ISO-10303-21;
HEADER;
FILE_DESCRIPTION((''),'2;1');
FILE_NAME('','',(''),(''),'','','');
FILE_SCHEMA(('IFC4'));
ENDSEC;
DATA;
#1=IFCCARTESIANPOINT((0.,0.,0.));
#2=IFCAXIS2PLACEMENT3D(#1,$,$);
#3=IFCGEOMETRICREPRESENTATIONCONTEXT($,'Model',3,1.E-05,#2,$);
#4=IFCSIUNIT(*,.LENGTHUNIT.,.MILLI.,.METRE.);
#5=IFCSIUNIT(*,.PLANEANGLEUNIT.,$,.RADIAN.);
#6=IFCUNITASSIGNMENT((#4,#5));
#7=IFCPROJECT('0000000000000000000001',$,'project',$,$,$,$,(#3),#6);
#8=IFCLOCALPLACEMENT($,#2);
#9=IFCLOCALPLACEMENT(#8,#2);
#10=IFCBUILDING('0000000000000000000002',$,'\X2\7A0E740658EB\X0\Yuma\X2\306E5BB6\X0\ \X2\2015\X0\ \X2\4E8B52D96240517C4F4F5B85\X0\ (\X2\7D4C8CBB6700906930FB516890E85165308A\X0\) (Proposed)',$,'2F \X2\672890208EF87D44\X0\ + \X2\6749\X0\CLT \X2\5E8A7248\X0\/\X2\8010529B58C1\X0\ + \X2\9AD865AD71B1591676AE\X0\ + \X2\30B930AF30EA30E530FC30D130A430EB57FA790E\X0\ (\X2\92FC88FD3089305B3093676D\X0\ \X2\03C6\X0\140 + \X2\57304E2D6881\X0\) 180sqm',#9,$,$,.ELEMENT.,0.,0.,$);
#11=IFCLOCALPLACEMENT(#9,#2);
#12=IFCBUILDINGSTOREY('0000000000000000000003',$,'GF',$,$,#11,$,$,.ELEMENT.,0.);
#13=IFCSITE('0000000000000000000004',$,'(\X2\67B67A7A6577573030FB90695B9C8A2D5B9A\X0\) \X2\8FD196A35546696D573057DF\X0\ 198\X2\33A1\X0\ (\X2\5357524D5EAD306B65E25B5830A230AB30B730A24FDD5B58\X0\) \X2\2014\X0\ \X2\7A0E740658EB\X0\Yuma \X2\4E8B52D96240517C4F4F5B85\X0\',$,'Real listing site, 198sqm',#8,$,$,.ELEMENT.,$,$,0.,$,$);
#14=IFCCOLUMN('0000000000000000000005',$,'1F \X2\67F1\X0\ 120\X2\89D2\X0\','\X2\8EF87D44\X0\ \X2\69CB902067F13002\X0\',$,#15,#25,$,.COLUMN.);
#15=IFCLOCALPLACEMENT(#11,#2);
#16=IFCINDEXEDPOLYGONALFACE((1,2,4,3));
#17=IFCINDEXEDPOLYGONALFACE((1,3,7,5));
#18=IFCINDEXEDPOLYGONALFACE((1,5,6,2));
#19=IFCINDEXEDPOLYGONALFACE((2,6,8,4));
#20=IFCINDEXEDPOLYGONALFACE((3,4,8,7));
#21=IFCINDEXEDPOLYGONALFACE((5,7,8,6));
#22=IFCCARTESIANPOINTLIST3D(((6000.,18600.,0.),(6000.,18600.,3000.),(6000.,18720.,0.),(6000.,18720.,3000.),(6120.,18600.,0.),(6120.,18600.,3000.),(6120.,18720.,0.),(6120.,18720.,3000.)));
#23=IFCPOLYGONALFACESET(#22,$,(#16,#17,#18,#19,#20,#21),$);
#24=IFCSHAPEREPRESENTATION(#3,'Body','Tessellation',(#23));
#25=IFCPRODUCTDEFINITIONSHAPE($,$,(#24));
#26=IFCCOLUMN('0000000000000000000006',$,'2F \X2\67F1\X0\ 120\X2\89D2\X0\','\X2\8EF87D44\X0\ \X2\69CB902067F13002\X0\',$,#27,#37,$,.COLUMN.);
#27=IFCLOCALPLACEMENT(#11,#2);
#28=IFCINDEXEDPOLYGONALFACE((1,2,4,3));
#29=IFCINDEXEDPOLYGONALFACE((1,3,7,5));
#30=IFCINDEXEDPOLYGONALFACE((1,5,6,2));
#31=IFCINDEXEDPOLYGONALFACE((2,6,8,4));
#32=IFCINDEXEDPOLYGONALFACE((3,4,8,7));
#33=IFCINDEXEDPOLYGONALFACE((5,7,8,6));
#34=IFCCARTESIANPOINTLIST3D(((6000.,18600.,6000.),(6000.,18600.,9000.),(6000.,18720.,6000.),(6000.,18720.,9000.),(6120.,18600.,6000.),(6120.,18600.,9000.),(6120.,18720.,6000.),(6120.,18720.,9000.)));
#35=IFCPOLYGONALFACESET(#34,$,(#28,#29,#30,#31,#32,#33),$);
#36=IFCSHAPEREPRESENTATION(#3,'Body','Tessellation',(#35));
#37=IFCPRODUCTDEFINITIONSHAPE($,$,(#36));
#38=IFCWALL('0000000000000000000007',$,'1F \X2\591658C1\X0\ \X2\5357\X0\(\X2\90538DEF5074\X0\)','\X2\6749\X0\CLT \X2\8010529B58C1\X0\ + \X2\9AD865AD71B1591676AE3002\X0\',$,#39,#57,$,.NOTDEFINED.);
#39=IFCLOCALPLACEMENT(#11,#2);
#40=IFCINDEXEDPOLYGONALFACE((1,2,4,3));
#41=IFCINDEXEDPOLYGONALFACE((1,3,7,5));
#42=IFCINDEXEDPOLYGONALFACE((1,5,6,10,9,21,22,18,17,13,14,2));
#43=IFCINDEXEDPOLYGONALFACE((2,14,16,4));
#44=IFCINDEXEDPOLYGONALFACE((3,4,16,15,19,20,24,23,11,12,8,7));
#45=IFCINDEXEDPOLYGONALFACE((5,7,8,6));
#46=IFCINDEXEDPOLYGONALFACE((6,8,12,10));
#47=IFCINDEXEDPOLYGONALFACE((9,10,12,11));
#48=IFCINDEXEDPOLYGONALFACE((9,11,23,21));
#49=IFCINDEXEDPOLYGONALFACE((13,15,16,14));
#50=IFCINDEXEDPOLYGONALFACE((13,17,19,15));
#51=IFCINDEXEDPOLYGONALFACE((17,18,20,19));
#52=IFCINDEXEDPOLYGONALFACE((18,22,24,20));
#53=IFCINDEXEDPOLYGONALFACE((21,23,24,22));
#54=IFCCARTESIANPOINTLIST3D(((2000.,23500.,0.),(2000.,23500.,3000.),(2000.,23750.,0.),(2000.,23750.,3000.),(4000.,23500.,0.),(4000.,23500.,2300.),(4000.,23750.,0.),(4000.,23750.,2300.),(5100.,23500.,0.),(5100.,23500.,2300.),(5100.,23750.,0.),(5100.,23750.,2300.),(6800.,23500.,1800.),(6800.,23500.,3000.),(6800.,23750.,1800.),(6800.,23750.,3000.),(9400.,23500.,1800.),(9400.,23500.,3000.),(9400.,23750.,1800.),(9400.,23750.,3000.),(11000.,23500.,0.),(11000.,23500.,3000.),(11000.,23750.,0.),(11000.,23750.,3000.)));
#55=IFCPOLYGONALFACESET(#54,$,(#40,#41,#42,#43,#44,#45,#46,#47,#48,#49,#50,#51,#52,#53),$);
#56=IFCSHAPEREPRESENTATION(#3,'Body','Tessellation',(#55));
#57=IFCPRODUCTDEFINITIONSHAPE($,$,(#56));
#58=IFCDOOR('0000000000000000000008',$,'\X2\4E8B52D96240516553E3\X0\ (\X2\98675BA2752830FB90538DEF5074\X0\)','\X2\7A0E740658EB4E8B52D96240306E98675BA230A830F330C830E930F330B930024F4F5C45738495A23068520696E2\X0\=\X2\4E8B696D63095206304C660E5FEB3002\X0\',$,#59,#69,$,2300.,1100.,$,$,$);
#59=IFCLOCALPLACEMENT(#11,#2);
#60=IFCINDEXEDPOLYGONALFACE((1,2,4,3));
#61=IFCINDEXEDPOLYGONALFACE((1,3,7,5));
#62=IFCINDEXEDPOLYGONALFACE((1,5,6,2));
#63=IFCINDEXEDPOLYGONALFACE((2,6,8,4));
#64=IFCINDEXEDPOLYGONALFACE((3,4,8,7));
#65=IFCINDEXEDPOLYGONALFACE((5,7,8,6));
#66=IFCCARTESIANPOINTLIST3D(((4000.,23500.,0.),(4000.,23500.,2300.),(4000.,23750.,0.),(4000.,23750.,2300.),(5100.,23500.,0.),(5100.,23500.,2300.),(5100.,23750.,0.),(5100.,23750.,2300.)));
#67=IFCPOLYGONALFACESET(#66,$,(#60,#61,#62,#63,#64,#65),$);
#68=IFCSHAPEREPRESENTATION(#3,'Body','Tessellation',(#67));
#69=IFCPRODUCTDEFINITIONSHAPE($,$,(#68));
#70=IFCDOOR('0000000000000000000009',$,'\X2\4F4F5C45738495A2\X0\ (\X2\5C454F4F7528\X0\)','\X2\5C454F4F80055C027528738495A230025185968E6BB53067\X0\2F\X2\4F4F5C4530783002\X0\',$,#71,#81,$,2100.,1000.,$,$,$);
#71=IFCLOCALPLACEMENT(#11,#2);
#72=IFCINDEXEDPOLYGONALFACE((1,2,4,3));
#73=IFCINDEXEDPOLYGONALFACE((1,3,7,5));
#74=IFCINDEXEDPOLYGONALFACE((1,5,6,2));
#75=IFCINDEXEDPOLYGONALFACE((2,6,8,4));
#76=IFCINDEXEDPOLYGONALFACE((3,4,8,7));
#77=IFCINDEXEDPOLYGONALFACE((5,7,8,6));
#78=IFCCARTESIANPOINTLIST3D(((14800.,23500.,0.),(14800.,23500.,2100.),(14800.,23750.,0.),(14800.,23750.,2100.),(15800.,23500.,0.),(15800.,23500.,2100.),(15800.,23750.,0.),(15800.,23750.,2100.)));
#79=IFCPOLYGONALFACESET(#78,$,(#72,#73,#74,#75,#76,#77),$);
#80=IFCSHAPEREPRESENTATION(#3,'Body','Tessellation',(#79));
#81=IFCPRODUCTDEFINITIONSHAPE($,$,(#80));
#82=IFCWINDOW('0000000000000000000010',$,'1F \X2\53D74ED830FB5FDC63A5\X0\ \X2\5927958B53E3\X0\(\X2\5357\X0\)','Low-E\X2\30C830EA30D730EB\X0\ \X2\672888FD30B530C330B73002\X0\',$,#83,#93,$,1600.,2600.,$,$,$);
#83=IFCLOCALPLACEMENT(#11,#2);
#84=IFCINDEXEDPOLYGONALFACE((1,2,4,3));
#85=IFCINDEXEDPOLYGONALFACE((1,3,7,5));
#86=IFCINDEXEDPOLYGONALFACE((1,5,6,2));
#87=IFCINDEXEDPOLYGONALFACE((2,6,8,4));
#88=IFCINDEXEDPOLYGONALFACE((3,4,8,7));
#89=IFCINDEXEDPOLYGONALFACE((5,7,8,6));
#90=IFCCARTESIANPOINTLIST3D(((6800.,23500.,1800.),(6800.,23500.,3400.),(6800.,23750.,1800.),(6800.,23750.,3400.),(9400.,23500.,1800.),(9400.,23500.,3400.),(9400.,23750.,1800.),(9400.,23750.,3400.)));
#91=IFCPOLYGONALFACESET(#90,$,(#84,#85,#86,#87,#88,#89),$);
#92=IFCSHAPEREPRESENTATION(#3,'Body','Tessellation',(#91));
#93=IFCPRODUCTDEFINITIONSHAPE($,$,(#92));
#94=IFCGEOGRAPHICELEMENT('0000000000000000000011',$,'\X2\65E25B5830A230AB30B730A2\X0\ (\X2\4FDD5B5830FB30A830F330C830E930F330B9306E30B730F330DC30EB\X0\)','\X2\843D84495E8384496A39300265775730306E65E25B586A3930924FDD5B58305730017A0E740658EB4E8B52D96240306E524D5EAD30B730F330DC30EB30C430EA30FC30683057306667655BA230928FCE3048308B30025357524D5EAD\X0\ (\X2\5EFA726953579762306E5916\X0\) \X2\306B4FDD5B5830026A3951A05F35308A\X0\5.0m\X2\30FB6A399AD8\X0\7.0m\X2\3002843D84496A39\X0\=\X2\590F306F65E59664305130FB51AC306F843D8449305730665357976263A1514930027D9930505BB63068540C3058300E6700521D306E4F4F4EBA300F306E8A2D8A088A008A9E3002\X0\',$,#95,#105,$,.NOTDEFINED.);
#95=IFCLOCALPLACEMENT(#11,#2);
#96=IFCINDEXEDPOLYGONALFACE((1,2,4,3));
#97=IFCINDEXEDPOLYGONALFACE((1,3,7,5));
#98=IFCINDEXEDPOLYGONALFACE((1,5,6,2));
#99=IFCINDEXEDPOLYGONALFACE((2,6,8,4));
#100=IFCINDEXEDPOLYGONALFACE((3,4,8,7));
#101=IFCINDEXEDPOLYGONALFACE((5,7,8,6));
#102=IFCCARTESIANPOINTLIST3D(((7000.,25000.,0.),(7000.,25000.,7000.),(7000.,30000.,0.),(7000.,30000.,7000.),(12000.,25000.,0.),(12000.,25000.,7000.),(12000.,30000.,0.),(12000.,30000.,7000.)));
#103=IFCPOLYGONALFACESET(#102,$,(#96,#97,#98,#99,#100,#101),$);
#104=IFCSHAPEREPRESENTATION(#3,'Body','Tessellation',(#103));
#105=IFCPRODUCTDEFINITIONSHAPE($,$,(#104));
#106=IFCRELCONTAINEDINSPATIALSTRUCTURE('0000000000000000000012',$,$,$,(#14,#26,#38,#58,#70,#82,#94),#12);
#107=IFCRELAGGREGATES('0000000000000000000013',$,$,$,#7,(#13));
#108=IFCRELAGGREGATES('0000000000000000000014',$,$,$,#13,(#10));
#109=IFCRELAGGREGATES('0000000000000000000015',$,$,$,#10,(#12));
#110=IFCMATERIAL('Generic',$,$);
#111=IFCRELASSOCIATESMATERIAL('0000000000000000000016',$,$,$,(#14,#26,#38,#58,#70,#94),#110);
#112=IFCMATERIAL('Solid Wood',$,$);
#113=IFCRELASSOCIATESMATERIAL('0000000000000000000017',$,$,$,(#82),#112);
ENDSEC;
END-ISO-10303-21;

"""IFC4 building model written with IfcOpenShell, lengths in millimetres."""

from ifc_helpers import new_model, si_unit, frame, frame_2d, origin, place, context, project, spatial, rectangle, extrude, material, element, fill, save


model = new_model("IFC4")

# Units and contexts
model_context = context("Model", 3, precision=1e-05, world=origin())
ifc_project = project(units=[si_unit("LENGTHUNIT", "METRE", prefix="MILLI"), si_unit("PLANEANGLEUNIT", "RADIAN")], contexts=[model_context])

# Site, building, storey
site_placement = place(None, origin())
site = spatial("IfcSite", under=ifc_project, at=site_placement, Name="(架空敷地・適宜設定) 近隣商業地域 198㎡ (南前庭に既存アカシア保存) — 税理士Yuma 事務所兼住宅", ObjectType="Real listing site, 198sqm", CompositionType="ELEMENT", RefElevation=0.0)
building_placement = place(site_placement, origin())
building = spatial("IfcBuilding", under=site, at=building_placement, Name="税理士Yumaの家 ― 事務所兼住宅 (経費最適・全部入り) (Proposed)", ObjectType="2F 木造軸組 + 杉CLT 床版/耐力壁 + 高断熱外皮 + スクリューパイル基礎 (鋼製らせん杭 φ140 + 地中梁) 180sqm", CompositionType="ELEMENT", ElevationOfRefHeight=0.0, ElevationOfTerrain=0.0)
storey_placement = place(building_placement, origin())
storey = spatial("IfcBuildingStorey", under=building, at=storey_placement, Name="GF", CompositionType="ELEMENT", Elevation=0.0)

# Columns
ifc_material_1 = material(Name="Generic")
column_1_placement = place(storey_placement, frame((3000.0, 9300.0, 0.0)))
element("IfcColumn", 1, at=column_1_placement, inside=storey, material=ifc_material_1, Name="1F 柱 120角", Description="軸組 構造柱。", PredefinedType="COLUMN", context=model_context, shape_type="SweptSolid", body=[
    extrude(rectangle(XDim=120.0, YDim=120.0, at=frame_2d((60.0, 60.0))), frame((3000.0, 9300.0, 0.0)), (0.0, 0.0, 1.0), 3000.0),
])
column_2_placement = place(storey_placement, frame((3000.0, 9300.0, 3000.0)))
element("IfcColumn", 2, at=column_2_placement, inside=storey, material=ifc_material_1, Name="2F 柱 120角", Description="軸組 構造柱。", PredefinedType="COLUMN", context=model_context, shape_type="SweptSolid", body=[
    extrude(rectangle(XDim=120.0, YDim=120.0, at=frame_2d((60.0, 60.0))), frame((3000.0, 9300.0, 3000.0)), (0.0, 0.0, 1.0), 3000.0),
])

# Wall, openings, doors, window
wall_1_placement = place(storey_placement, frame((1000.0, 11750.0, 0.0)))
wall_1 = element("IfcWall", 3, at=wall_1_placement, inside=storey, material=ifc_material_1, Name="1F 外壁 南(道路側)", Description="杉CLT 耐力壁 + 高断熱外皮。", PredefinedType="NOTDEFINED", context=model_context, shape_type="SweptSolid", body=[
    extrude(rectangle(XDim=9000.0, YDim=250.0, at=frame_2d((4500.0, 125.0))), frame((1000.0, 11750.0, 0.0)), (0.0, 0.0, 1.0), 3000.0),
])
opening_1_placement = place(storey_placement, frame((2000.0, 11750.0, 0.0)))
opening_1 = element("IfcOpeningElement", 4, at=opening_1_placement, cuts=wall_1, PredefinedType="NOTDEFINED", context=model_context, shape_type="SweptSolid", body=[
    extrude(rectangle(XDim=1100.0, YDim=250.0, at=frame_2d((550.0, 125.0))), frame((2000.0, 11750.0, 0.0)), (0.0, 0.0, 1.0), 2300.0),
])
opening_2_placement = place(storey_placement, frame((7400.0, 11750.0, 0.0)))
opening_2 = element("IfcOpeningElement", 5, at=opening_2_placement, cuts=wall_1, PredefinedType="NOTDEFINED", context=model_context, shape_type="SweptSolid", body=[
    extrude(rectangle(XDim=1000.0, YDim=250.0, at=frame_2d((500.0, 125.0))), frame((7400.0, 11750.0, 0.0)), (0.0, 0.0, 1.0), 2100.0),
])
opening_3_placement = place(storey_placement, frame((3400.0, 11750.0, 900.0)))
opening_3 = element("IfcOpeningElement", 6, at=opening_3_placement, cuts=wall_1, PredefinedType="NOTDEFINED", context=model_context, shape_type="SweptSolid", body=[
    extrude(rectangle(XDim=2600.0, YDim=250.0, at=frame_2d((1300.0, 125.0))), frame((3400.0, 11750.0, 900.0)), (0.0, 0.0, 1.0), 1600.0),
])
door_1_placement = place(storey_placement, frame((2000.0, 11750.0, 0.0)))
door_1 = element("IfcDoor", 7, at=door_1_placement, inside=storey, material=ifc_material_1, Name="事務所入口 (顧客用・道路側)", Description="税理士事務所の顧客エントランス。住居玄関と分離=事業按分が明快。", OverallHeight=2300.0, OverallWidth=1100.0, context=model_context, shape_type="SweptSolid", body=[
    extrude(rectangle(XDim=1100.0, YDim=250.0, at=frame_2d((550.0, 125.0))), frame((2000.0, 11750.0, 0.0)), (0.0, 0.0, 1.0), 2300.0),
])
fill(opening_1, door_1)
door_2_placement = place(storey_placement, frame((7400.0, 11750.0, 0.0)))
door_2 = element("IfcDoor", 8, at=door_2_placement, inside=storey, material=ifc_material_1, Name="住居玄関 (居住用)", Description="居住者専用玄関。内階段で2F住居へ。", OverallHeight=2100.0, OverallWidth=1000.0, context=model_context, shape_type="SweptSolid", body=[
    extrude(rectangle(XDim=1000.0, YDim=250.0, at=frame_2d((500.0, 125.0))), frame((7400.0, 11750.0, 0.0)), (0.0, 0.0, 1.0), 2100.0),
])
fill(opening_2, door_2)
ifc_material_2 = material(Name="Solid Wood")
window_1_placement = place(storey_placement, frame((3400.0, 11750.0, 900.0)))
window_1 = element("IfcWindow", 9, at=window_1_placement, inside=storey, material=ifc_material_2, Name="1F 受付・応接 大開口(南)", Description="Low-Eトリプル 木製サッシ。", OverallHeight=1600.0, OverallWidth=2600.0, context=model_context, shape_type="SweptSolid", body=[
    extrude(rectangle(XDim=2600.0, YDim=250.0, at=frame_2d((1300.0, 125.0))), frame((3400.0, 11750.0, 900.0)), (0.0, 0.0, 1.0), 1600.0),
])
fill(opening_3, window_1)

# Geographic element
geographic_element_placement = place(storey_placement, frame((3500.0, 12500.0, 0.0)))
element("IfcGeographicElement", 10, at=geographic_element_placement, inside=storey, material=ifc_material_1, Name="既存アカシア (保存・エントランスのシンボル)", Description="落葉広葉樹。敷地の既存樹を保存し、税理士事務所の前庭シンボルツリーとして来客を迎える。南前庭 (建物南面の外) に保存。樹冠張り5.0m・樹高7.0m。落葉樹=夏は日除け・冬は落葉して南面採光。継ぐ家と同じ『最初の住人』の設計言語。", PredefinedType="NOTDEFINED", context=model_context, shape_type="SweptSolid", body=[
    extrude(rectangle(XDim=5000.0, YDim=5000.0, at=frame_2d((2500.0, 2500.0))), frame((3500.0, 12500.0, 0.0)), (0.0, 0.0, 1.0), 7000.0),
])

save(model, "model.ifc")
